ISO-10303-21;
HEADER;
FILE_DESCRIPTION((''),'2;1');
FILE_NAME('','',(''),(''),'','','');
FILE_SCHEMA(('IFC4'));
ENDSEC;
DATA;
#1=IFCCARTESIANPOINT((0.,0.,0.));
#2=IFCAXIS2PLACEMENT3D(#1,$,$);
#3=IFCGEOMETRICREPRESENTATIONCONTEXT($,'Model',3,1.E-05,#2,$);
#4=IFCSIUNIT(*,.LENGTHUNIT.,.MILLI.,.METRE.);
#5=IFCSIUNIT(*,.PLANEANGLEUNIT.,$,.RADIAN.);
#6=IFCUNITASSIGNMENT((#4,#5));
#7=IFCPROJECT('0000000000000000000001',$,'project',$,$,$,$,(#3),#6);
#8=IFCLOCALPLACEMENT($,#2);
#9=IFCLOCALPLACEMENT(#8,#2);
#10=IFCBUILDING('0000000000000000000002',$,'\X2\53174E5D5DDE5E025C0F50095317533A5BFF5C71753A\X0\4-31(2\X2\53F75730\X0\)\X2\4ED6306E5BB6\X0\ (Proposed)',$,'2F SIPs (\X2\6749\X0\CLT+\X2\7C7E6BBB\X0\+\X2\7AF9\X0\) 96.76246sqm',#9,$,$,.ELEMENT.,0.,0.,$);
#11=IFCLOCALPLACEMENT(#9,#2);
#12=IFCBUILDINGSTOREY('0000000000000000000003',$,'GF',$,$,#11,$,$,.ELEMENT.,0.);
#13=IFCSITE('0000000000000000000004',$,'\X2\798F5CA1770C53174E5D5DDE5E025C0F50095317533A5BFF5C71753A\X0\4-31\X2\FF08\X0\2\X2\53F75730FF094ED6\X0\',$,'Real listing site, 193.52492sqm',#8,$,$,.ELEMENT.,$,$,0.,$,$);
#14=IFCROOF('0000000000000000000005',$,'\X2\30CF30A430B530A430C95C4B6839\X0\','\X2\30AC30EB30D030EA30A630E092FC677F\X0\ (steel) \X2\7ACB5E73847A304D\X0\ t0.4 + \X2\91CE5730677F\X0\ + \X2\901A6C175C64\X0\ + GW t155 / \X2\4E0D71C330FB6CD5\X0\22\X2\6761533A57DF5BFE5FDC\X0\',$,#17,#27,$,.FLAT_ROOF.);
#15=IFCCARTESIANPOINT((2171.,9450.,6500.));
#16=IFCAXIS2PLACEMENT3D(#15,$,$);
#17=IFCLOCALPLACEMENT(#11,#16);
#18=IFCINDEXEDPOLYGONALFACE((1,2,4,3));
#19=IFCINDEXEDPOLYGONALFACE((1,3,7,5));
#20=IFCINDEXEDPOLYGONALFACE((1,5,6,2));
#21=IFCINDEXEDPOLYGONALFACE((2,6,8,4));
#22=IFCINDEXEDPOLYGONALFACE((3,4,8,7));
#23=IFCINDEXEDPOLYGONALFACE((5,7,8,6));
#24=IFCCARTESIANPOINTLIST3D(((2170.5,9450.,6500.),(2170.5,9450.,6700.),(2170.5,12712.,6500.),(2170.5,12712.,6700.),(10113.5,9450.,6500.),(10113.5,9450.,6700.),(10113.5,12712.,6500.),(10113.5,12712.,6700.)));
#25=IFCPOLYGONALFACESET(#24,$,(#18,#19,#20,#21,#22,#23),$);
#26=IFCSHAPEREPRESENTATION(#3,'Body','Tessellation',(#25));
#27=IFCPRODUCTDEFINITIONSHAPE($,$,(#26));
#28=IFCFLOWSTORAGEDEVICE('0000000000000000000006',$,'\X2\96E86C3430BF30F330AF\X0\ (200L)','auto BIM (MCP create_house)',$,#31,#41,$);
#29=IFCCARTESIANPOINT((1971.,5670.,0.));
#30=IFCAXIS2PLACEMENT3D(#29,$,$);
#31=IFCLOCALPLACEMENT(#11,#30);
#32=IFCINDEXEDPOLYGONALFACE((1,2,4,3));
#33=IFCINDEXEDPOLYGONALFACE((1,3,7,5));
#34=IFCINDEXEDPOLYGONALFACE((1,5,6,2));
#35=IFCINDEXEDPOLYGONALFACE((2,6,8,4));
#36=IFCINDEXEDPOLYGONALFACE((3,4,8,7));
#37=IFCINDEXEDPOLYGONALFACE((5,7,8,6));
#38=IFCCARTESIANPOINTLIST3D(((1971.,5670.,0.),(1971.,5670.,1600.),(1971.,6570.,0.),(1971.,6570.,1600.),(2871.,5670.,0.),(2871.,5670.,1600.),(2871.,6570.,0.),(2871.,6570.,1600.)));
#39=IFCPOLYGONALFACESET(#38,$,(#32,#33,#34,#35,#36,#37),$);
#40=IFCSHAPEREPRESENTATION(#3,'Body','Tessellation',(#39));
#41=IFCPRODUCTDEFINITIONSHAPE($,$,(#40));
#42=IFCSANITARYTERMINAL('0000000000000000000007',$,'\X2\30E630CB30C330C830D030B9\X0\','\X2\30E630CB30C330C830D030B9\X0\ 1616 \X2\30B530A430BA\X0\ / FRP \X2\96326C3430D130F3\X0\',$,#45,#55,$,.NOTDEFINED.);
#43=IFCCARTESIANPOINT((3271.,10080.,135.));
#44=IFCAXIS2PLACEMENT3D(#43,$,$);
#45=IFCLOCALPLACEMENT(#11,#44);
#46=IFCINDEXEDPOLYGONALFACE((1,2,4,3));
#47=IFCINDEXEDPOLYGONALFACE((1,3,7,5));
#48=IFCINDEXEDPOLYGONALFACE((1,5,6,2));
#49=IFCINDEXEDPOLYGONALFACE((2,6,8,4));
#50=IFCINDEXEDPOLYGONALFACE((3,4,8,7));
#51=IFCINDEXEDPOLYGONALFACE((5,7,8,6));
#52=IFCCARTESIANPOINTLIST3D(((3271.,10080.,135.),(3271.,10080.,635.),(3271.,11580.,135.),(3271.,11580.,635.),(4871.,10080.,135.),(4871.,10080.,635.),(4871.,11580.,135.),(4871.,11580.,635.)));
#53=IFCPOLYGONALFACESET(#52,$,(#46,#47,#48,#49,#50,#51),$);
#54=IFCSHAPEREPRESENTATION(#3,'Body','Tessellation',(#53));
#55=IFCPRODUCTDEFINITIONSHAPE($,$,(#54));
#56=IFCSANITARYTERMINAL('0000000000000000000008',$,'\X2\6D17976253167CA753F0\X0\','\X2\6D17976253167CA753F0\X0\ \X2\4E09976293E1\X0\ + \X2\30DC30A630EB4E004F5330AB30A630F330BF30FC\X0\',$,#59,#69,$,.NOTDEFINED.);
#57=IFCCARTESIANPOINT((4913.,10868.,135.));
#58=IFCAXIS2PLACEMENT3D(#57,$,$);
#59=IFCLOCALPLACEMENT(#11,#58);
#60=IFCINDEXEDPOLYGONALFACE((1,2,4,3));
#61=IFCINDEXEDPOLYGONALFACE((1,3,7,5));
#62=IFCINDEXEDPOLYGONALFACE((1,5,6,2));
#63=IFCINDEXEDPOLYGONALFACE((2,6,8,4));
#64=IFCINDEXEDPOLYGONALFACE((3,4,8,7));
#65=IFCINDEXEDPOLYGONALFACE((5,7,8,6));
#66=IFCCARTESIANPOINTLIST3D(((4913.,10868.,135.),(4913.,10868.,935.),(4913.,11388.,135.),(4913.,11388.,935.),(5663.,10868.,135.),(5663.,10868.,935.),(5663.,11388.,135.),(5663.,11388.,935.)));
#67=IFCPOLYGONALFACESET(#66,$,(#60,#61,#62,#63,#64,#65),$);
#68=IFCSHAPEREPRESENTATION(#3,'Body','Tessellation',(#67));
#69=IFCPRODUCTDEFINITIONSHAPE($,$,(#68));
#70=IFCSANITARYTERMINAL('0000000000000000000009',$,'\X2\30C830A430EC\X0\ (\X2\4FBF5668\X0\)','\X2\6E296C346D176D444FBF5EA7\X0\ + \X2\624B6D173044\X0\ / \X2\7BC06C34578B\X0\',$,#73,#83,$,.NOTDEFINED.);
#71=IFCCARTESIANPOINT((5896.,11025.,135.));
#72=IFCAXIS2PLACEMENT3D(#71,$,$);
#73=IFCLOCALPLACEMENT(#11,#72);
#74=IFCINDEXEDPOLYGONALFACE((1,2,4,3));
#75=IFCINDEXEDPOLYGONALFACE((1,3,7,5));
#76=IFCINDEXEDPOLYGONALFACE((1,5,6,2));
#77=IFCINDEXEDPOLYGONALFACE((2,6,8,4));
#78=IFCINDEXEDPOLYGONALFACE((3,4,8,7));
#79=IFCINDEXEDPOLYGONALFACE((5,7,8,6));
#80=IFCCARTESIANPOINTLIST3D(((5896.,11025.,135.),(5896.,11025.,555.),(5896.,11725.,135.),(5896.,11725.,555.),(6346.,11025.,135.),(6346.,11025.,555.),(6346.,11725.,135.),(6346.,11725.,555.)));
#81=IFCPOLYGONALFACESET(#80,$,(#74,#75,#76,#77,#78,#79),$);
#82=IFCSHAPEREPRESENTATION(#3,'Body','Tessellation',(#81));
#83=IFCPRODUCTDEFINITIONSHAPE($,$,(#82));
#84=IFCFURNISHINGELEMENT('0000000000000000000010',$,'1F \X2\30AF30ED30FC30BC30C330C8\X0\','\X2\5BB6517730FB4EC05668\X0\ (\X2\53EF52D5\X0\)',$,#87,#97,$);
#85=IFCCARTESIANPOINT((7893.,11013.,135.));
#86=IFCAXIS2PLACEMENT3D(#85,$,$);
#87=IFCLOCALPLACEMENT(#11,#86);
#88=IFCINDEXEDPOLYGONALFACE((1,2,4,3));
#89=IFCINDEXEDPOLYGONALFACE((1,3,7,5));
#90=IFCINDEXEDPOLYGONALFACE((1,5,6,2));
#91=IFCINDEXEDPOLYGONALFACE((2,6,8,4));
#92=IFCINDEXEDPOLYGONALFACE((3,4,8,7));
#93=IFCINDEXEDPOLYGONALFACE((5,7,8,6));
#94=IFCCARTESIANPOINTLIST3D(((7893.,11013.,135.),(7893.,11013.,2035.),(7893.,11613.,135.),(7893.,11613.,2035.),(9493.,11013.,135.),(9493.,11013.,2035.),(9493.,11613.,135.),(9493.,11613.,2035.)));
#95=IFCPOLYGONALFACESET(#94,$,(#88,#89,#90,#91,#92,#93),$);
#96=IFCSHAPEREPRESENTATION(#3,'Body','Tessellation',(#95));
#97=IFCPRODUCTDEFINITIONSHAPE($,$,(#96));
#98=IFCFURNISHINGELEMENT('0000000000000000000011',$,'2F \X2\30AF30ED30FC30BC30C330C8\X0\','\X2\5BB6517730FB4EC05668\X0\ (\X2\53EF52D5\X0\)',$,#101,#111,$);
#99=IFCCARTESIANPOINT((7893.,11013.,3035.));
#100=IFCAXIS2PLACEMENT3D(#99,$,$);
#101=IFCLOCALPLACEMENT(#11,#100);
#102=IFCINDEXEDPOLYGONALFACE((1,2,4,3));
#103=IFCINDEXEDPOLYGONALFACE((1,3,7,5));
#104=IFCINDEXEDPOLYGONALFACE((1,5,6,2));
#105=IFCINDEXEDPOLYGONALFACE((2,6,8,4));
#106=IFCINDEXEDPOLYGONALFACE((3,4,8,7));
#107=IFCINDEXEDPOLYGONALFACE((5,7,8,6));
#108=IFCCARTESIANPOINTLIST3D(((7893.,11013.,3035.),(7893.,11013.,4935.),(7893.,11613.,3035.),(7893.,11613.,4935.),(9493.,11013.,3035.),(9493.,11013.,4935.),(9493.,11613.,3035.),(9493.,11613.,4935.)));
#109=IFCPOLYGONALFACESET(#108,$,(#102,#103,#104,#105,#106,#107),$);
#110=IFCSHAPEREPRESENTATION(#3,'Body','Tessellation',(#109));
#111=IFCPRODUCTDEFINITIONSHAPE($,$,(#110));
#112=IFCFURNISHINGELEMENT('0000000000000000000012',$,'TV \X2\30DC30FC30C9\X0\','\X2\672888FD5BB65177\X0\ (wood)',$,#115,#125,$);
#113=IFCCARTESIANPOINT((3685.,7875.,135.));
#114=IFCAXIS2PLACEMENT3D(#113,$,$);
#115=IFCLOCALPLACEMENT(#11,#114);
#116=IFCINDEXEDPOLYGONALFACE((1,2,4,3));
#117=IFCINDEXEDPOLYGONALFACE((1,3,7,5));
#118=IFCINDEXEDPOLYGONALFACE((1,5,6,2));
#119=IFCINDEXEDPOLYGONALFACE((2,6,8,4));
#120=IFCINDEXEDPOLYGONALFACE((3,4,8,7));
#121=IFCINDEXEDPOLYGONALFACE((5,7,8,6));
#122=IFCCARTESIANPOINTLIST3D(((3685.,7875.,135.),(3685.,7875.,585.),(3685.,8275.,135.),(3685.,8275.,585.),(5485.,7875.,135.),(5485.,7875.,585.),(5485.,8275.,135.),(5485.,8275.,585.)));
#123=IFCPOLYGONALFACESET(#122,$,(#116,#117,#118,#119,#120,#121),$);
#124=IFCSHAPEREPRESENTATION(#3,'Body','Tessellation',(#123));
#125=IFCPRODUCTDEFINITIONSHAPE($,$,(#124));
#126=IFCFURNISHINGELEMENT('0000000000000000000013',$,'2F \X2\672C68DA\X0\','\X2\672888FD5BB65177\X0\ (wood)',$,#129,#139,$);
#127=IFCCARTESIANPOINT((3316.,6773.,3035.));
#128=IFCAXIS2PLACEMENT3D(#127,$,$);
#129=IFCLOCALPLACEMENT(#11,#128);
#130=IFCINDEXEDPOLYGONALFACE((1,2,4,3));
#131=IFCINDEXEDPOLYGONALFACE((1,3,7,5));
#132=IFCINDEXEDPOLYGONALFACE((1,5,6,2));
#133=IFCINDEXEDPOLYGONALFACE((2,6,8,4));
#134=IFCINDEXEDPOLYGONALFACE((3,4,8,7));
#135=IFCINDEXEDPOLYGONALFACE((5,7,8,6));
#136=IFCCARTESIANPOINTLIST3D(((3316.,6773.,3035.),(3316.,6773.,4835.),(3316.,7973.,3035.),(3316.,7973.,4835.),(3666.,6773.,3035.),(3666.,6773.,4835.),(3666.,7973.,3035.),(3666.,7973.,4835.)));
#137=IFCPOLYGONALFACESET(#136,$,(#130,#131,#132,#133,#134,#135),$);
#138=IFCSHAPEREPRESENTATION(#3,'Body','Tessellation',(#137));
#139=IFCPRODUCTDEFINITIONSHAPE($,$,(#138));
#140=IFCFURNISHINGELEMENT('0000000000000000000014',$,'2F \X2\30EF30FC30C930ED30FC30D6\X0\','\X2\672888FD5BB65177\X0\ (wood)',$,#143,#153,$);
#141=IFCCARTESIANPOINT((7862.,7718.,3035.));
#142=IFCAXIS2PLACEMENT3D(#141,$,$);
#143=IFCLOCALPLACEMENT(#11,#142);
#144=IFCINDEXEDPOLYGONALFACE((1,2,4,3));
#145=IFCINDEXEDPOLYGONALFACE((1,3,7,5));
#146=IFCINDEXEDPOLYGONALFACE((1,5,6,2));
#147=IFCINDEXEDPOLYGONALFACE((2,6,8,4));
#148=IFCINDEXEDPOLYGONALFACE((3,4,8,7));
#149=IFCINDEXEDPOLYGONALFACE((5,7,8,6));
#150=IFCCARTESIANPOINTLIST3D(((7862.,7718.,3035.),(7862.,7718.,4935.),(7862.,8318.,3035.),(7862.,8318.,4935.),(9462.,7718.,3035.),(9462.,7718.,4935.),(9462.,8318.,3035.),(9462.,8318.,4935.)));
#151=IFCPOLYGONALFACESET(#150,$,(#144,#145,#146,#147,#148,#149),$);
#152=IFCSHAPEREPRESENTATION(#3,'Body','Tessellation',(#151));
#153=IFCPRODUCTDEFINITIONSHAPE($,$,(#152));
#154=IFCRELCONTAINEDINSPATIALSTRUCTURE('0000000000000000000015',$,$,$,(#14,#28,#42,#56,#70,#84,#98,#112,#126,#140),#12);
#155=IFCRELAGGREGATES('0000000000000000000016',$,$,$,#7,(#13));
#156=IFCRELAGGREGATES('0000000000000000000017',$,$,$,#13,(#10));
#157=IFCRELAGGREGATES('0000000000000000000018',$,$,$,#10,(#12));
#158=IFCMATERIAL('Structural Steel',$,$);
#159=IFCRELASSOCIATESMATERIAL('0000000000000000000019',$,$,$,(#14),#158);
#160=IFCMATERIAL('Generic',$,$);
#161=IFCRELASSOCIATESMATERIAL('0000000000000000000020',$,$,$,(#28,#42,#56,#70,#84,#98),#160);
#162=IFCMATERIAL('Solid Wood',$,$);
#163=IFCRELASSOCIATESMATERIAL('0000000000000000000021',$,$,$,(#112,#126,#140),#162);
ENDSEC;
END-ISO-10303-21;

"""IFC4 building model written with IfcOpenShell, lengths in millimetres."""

from ifc_helpers import new_model, si_unit, frame, frame_2d, origin, place, context, project, spatial, rectangle, extrude, material, element, save


model = new_model("IFC4")

# Units and contexts
model_context = context("Model", 3, precision=1e-05, world=origin())
ifc_project = project(units=[si_unit("LENGTHUNIT", "METRE", prefix="MILLI"), si_unit("PLANEANGLEUNIT", "RADIAN")], contexts=[model_context])

# Site, building, storey
site_placement = place(None, origin())
site = spatial("IfcSite", under=ifc_project, at=site_placement, Name="福岡県北九州市小倉北区寿山町4-31（2号地）他", ObjectType="Real listing site, 193.52492sqm", CompositionType="ELEMENT", RefElevation=0.0)
building_placement = place(site_placement, origin())
building = spatial("IfcBuilding", under=site, at=building_placement, Name="北九州市小倉北区寿山町4-31(2号地)他の家 (Proposed)", ObjectType="2F SIPs (杉CLT+籾殻+竹) 96.76246sqm", CompositionType="ELEMENT", ElevationOfRefHeight=0.0, ElevationOfTerrain=0.0)
storey_placement = place(building_placement, origin())
storey = spatial("IfcBuildingStorey", under=building, at=storey_placement, Name="GF", CompositionType="ELEMENT", Elevation=0.0)

# Shared definitions
ifc_material_1 = material(Name="Solid Wood")

# Roof
ifc_material_2 = material(Name="Structural Steel")
roof_placement = place(storey_placement, frame((2171.0, 9450.0, 6500.0)))
element("IfcRoof", 1, at=roof_placement, inside=storey, material=ifc_material_2, Name="ハイサイド屋根", Description="ガルバリウム鋼板 (steel) 立平葺き t0.4 + 野地板 + 通気層 + GW t155 / 不燃・法22条区域対応", PredefinedType="FLAT_ROOF", context=model_context, shape_type="SweptSolid", body=[
    extrude(rectangle(XDim=7943.0, YDim=3262.0, at=frame_2d((3971.0, 1631.0))), frame((2171.0, 9450.0, 6500.0)), (0.0, 0.0, 1.0), 200.0),
])

# Flow storage device
ifc_material_3 = material(Name="Generic")
flow_storage_device_placement = place(storey_placement, frame((1971.0, 5670.0, 0.0)))
element("IfcFlowStorageDevice", 2, at=flow_storage_device_placement, inside=storey, material=ifc_material_3, Name="雨水タンク (200L)", Description="auto BIM (MCP create_house)", context=model_context, shape_type="SweptSolid", body=[
    extrude(rectangle(XDim=900.0, YDim=900.0, at=frame_2d((450.0, 450.0))), frame((1971.0, 5670.0, 0.0)), (0.0, 0.0, 1.0), 1600.0),
])

# Sanitary terminals
sanitary_terminal_1_placement = place(storey_placement, frame((3271.0, 10080.0, 135.0)))
element("IfcSanitaryTerminal", 3, at=sanitary_terminal_1_placement, inside=storey, material=ifc_material_3, Name="ユニットバス", Description="ユニットバス 1616 サイズ / FRP 防水パン", PredefinedType="NOTDEFINED", context=model_context, shape_type="SweptSolid", body=[
    extrude(rectangle(XDim=1600.0, YDim=1500.0, at=frame_2d((800.0, 750.0))), frame((3271.0, 10080.0, 135.0)), (0.0, 0.0, 1.0), 500.0),
])
sanitary_terminal_2_placement = place(storey_placement, frame((4913.0, 10868.0, 135.0)))
element("IfcSanitaryTerminal", 4, at=sanitary_terminal_2_placement, inside=storey, material=ifc_material_3, Name="洗面化粧台", Description="洗面化粧台 三面鏡 + ボウル一体カウンター", PredefinedType="NOTDEFINED", context=model_context, shape_type="SweptSolid", body=[
    extrude(rectangle(XDim=750.0, YDim=520.0, at=frame_2d((375.0, 260.0))), frame((4913.0, 10868.0, 135.0)), (0.0, 0.0, 1.0), 800.0),
])
sanitary_terminal_3_placement = place(storey_placement, frame((5896.0, 11025.0, 135.0)))
element("IfcSanitaryTerminal", 5, at=sanitary_terminal_3_placement, inside=storey, material=ifc_material_3, Name="トイレ (便器)", Description="温水洗浄便座 + 手洗い / 節水型", PredefinedType="NOTDEFINED", context=model_context, shape_type="SweptSolid", body=[
    extrude(rectangle(XDim=450.0, YDim=700.0, at=frame_2d((225.0, 350.0))), frame((5896.0, 11025.0, 135.0)), (0.0, 0.0, 1.0), 420.0),
])

# Furnishing elements
furnishing_1_placement = place(storey_placement, frame((7893.0, 11013.0, 135.0)))
element("IfcFurnishingElement", 6, at=furnishing_1_placement, inside=storey, material=ifc_material_3, Name="1F クローゼット", Description="家具・什器 (可動)", context=model_context, shape_type="SweptSolid", body=[
    extrude(rectangle(XDim=1600.0, YDim=600.0, at=frame_2d((800.0, 300.0))), frame((7893.0, 11013.0, 135.0)), (0.0, 0.0, 1.0), 1900.0),
])
furnishing_2_placement = place(storey_placement, frame((7893.0, 11013.0, 3035.0)))
element("IfcFurnishingElement", 7, at=furnishing_2_placement, inside=storey, material=ifc_material_3, Name="2F クローゼット", Description="家具・什器 (可動)", context=model_context, shape_type="SweptSolid", body=[
    extrude(rectangle(XDim=1600.0, YDim=600.0, at=frame_2d((800.0, 300.0))), frame((7893.0, 11013.0, 3035.0)), (0.0, 0.0, 1.0), 1900.0),
])
furnishing_3_placement = place(storey_placement, frame((3685.0, 7875.0, 135.0)))
element("IfcFurnishingElement", 8, at=furnishing_3_placement, inside=storey, material=ifc_material_1, Name="TV ボード", Description="木製家具 (wood)", context=model_context, shape_type="SweptSolid", body=[
    extrude(rectangle(XDim=1800.0, YDim=400.0, at=frame_2d((900.0, 200.0))), frame((3685.0, 7875.0, 135.0)), (0.0, 0.0, 1.0), 450.0),
])
furnishing_4_placement = place(storey_placement, frame((3316.0, 6773.0, 3035.0)))
element("IfcFurnishingElement", 9, at=furnishing_4_placement, inside=storey, material=ifc_material_1, Name="2F 本棚", Description="木製家具 (wood)", context=model_context, shape_type="SweptSolid", body=[
    extrude(rectangle(XDim=350.0, YDim=1200.0, at=frame_2d((175.0, 600.0))), frame((3316.0, 6773.0, 3035.0)), (0.0, 0.0, 1.0), 1800.0),
])
furnishing_5_placement = place(storey_placement, frame((7862.0, 7718.0, 3035.0)))
element("IfcFurnishingElement", 10, at=furnishing_5_placement, inside=storey, material=ifc_material_1, Name="2F ワードローブ", Description="木製家具 (wood)", context=model_context, shape_type="SweptSolid", body=[
    extrude(rectangle(XDim=1600.0, YDim=600.0, at=frame_2d((800.0, 300.0))), frame((7862.0, 7718.0, 3035.0)), (0.0, 0.0, 1.0), 1900.0),
])

save(model, "model.ifc")
